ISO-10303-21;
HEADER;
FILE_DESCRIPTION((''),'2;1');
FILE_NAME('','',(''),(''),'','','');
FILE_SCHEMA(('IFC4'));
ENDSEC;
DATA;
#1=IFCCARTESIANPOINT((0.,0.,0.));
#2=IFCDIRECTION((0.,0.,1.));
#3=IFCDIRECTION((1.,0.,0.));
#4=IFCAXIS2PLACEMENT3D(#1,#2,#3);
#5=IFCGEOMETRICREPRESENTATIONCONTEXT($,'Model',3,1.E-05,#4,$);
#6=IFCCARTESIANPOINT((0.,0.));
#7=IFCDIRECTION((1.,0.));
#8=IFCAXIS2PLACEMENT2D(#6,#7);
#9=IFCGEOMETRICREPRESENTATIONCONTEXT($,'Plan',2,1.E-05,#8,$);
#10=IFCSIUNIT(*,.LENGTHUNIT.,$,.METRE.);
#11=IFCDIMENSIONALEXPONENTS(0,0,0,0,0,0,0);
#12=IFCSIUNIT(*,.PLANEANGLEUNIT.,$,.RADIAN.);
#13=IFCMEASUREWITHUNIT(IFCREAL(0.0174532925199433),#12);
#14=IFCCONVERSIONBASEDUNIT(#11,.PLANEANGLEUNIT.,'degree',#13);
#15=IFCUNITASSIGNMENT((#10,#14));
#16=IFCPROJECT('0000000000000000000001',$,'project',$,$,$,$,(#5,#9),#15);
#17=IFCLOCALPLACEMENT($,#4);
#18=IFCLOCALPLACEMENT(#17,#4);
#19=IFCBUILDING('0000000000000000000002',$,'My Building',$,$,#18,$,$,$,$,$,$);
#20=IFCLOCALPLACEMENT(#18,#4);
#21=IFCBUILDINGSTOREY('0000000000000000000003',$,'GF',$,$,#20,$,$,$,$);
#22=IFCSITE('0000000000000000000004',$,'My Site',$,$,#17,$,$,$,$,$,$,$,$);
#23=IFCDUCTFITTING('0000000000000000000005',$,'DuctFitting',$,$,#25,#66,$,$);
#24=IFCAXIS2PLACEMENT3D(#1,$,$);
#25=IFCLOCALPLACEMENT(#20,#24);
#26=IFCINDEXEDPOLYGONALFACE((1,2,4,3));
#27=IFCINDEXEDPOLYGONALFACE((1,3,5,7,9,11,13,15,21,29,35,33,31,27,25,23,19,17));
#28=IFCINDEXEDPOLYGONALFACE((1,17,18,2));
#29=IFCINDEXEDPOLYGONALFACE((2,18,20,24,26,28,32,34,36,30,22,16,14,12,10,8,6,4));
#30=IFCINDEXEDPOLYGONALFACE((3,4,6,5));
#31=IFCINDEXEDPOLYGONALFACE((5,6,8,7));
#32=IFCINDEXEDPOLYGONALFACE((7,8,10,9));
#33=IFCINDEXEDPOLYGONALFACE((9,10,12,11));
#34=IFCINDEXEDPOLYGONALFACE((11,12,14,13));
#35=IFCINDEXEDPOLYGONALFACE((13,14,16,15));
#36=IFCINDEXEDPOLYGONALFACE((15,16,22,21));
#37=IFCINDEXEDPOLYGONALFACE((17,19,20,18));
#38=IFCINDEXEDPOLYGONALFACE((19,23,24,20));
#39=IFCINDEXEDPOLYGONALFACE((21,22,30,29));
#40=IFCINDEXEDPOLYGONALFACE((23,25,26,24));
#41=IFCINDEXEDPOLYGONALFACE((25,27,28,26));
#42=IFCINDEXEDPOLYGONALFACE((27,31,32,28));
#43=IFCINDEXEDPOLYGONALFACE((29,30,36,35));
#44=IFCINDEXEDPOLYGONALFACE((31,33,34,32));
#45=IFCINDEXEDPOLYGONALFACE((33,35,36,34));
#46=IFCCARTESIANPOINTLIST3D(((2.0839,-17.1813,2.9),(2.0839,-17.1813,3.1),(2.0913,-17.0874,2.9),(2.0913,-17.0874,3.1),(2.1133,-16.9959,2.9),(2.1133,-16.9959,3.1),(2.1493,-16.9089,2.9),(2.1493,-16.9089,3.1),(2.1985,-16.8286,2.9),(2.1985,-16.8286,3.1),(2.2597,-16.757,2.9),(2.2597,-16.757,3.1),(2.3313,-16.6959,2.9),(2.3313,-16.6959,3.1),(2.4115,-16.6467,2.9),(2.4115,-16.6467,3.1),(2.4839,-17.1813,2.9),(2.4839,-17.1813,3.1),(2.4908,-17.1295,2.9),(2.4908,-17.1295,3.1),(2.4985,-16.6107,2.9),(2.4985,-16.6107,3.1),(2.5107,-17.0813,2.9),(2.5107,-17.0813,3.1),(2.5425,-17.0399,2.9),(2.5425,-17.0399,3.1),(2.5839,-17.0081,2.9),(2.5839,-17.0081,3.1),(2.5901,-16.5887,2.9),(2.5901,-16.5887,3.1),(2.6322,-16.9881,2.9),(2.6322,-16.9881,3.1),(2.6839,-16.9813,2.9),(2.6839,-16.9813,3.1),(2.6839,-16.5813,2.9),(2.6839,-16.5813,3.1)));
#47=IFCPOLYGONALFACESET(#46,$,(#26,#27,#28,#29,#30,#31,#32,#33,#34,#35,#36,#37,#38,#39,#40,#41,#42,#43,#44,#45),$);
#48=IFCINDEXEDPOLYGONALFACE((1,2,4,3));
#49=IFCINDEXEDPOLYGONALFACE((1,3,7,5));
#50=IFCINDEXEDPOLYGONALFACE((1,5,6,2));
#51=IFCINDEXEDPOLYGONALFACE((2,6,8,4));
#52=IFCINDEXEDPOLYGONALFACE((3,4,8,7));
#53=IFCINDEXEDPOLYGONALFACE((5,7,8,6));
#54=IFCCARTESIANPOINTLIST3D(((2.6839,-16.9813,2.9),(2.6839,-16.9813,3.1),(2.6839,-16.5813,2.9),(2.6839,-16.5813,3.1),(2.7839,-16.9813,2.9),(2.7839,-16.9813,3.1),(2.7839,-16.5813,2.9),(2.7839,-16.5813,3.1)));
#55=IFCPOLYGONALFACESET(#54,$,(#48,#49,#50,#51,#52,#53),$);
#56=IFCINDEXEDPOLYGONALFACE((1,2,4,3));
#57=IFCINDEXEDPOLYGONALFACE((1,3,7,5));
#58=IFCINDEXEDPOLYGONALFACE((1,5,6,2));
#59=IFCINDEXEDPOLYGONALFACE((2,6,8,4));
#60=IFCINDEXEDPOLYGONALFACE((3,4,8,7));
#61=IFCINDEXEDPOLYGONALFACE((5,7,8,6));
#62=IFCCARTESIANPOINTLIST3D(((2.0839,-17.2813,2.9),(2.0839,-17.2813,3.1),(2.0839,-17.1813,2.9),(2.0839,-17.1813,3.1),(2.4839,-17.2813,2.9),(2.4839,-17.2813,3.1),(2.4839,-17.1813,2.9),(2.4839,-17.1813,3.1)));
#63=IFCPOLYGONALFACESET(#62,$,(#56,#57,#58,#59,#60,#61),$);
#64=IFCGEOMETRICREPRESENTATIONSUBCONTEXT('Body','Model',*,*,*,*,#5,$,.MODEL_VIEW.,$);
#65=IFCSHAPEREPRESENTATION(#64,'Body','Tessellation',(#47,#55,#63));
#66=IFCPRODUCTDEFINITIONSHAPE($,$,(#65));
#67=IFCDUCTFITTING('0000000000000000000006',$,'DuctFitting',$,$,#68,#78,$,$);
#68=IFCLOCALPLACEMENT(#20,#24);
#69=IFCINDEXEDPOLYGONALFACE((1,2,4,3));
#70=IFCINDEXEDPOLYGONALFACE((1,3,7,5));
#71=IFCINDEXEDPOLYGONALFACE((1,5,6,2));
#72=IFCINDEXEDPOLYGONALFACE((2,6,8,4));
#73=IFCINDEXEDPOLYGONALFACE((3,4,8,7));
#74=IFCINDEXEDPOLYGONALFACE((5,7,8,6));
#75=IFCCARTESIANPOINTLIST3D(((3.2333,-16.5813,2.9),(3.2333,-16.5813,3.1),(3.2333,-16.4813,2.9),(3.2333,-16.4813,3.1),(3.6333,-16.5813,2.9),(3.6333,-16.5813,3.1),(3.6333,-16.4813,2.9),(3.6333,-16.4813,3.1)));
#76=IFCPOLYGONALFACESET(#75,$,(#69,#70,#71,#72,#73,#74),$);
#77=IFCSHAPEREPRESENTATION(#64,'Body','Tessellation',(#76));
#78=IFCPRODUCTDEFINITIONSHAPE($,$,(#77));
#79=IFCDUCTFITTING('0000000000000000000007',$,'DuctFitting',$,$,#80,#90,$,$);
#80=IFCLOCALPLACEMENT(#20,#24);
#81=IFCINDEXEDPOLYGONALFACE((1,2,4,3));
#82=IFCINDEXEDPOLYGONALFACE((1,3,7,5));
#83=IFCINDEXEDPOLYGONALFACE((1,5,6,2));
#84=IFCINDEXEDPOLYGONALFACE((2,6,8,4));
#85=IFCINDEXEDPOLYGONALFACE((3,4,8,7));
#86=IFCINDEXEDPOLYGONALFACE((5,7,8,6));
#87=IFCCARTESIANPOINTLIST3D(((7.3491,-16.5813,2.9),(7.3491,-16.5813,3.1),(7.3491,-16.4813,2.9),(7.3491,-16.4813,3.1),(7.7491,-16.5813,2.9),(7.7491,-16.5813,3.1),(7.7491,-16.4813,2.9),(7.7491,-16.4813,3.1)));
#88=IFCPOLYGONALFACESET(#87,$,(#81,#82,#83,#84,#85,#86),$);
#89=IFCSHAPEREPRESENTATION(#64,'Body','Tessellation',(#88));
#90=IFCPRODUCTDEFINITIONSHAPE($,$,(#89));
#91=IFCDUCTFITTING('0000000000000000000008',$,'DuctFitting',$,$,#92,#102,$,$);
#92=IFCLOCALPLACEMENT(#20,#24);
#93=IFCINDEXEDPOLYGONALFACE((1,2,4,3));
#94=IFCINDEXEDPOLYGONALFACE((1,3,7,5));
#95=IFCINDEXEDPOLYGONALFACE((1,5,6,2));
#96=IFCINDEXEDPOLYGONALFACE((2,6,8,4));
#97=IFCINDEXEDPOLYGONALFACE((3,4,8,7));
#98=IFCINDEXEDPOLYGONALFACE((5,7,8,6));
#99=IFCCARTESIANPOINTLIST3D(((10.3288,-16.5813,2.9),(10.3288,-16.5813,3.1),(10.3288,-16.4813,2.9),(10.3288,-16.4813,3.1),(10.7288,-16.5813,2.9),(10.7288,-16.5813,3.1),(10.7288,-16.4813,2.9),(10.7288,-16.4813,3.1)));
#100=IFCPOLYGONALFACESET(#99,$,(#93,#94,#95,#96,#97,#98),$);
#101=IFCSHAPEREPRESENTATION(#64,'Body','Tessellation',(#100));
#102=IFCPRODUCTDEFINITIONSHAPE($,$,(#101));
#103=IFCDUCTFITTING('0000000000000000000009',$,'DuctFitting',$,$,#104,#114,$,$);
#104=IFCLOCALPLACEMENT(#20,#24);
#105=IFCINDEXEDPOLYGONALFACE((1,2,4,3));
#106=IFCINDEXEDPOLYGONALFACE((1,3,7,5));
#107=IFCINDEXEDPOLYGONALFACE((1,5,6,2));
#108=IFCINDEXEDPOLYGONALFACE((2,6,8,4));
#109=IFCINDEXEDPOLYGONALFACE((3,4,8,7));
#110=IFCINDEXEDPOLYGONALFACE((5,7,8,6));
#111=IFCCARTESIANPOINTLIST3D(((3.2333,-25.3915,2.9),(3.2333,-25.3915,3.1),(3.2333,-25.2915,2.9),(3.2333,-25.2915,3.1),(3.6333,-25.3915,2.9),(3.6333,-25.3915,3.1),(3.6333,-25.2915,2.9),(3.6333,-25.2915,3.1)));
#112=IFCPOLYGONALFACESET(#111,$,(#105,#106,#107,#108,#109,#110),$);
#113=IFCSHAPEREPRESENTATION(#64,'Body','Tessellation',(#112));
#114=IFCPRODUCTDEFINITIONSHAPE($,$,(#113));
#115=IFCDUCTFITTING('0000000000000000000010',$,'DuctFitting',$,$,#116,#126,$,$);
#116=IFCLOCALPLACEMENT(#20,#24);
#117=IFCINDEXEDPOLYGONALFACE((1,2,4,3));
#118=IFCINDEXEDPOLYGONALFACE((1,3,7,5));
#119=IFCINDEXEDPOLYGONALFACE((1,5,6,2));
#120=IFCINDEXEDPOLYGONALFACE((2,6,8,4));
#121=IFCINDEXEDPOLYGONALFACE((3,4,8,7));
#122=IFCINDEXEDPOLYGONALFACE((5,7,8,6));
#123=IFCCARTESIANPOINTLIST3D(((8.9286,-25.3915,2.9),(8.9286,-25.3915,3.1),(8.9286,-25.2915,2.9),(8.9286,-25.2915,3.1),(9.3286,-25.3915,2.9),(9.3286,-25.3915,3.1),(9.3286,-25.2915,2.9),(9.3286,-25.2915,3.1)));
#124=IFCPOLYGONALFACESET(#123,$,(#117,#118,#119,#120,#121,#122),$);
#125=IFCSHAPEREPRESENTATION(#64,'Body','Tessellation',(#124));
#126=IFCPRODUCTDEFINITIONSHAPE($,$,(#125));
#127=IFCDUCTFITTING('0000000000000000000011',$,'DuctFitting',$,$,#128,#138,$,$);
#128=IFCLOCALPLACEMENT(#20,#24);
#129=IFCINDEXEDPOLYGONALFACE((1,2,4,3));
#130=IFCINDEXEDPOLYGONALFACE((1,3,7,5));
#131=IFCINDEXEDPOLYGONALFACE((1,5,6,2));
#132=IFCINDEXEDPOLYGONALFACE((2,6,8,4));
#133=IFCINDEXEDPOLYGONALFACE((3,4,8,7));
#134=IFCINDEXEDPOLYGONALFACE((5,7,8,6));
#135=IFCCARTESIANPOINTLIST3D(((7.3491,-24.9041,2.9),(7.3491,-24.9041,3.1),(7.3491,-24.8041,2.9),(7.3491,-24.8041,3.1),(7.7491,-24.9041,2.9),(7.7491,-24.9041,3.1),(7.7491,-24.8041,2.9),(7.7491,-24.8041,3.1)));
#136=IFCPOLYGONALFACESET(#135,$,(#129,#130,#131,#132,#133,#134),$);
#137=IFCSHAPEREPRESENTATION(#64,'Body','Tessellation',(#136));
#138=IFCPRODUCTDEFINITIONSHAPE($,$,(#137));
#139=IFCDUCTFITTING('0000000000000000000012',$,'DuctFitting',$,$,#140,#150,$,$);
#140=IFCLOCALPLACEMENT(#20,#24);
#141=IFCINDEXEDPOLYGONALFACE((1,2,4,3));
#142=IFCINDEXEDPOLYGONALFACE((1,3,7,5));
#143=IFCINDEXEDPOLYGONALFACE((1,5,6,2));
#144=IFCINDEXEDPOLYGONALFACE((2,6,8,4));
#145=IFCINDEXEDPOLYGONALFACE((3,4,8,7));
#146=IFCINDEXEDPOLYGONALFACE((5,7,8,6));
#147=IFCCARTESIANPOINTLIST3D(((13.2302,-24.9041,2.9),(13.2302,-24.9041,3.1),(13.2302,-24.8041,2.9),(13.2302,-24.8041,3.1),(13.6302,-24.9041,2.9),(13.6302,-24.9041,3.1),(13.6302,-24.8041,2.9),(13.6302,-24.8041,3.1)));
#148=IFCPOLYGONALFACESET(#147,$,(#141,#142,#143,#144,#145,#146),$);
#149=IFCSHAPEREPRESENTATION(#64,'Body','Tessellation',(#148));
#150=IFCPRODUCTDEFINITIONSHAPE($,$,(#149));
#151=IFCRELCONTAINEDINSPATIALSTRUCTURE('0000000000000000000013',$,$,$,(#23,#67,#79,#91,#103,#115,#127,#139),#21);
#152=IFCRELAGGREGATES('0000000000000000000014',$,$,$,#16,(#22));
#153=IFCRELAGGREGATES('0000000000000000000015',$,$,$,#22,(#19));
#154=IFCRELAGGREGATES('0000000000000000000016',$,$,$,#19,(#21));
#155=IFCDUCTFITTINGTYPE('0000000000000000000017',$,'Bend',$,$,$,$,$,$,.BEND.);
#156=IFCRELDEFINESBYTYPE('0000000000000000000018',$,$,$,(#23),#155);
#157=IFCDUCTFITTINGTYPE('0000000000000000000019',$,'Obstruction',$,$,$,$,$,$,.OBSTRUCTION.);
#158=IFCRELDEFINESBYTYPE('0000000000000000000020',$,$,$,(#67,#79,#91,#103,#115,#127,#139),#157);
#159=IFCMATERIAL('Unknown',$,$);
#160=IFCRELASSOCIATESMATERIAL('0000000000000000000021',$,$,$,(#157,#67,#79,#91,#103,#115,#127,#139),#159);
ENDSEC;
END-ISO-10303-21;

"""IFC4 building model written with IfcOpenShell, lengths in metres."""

from ifc_helpers import new_model, entity, si_unit, converted_unit, frame, origin_with_axes, origin_2d_with_axis, place, context, subcontext, project, spatial, line, arc, indexed_curve, rectangle, outline, extrude, source, transform, mapped, material, material_profile, profile_set, profile_usage, type_object, type_shapes, element, save


model = new_model("IFC4")

# Units and contexts
model_context = context("Model", 3, precision=1e-05, world=origin_with_axes())
plan_context = context("Plan", 2, precision=1e-05, world=origin_2d_with_axis())
body_context_1 = subcontext(model_context, "Body", "Model", "MODEL_VIEW")
ifc_project = project(units=[si_unit("LENGTHUNIT", "METRE"), converted_unit("PLANEANGLEUNIT", "degree", entity("IfcReal", 0.0174532925199433), si_unit("PLANEANGLEUNIT", "RADIAN"), dimensions=[0, 0, 0, 0, 0, 0, 0])], contexts=[model_context, plan_context])

# Site, building, storey
site_placement = place(None, origin_with_axes())
site = spatial("IfcSite", under=ifc_project, at=site_placement, Name="My Site")
building_placement = place(site_placement, origin_with_axes())
building = spatial("IfcBuilding", under=site, at=building_placement, Name="My Building")
storey_placement = place(building_placement, origin_with_axes())
storey = spatial("IfcBuildingStorey", under=building, at=storey_placement, Name="GF")

# Shared definitions
ifc_material = material(Name="Unknown")

# Duct fittings
duct_fitting_type_1 = type_object("IfcDuctFittingType", Name="Bend", PredefinedType="BEND")
shared_shape_1 = source(origin_with_axes(), body_context_1, "Body", "SweptSolid", [
    extrude(outline(indexed_curve([(0.2, 0.0), (0.2586, -0.1414), (0.4, -0.2), (0.4, -0.6), (-0.0243, -0.4243), (-0.2, 0.0)], segments=[arc(1, 2, 3), line(3, 4), arc(4, 5, 6), line(6, 1)])), frame((0.0, -0.1, -0.1), z_axis=(0.0, -1.0, 0.0), x_axis=(1.0, 0.0, 0.0)), (0.0, 0.0, -1.0), 0.2),
    extrude(rectangle(XDim=0.4, YDim=0.2), origin_with_axes(), (0.0, 0.0, -1.0), 0.1),
    extrude(rectangle(XDim=0.4, YDim=0.2), frame((0.4, 0.0, -0.5), z_axis=(1.0, 0.0, 0.0), x_axis=(0.0, 0.0, 1.0)), (0.0, 0.0, 1.0), 0.1),
])
type_shapes(duct_fitting_type_1, [shared_shape_1])
duct_fitting_1_placement = place(storey_placement, frame((2.7839, -16.7813, 3.0), z_axis=(1.0, 0.0, 0.0), x_axis=(0.0, -1.0, 0.0)))
element("IfcDuctFitting", 1, at=duct_fitting_1_placement, inside=storey, type_object=duct_fitting_type_1, Name="DuctFitting", context=body_context_1, shape_type="MappedRepresentation", body=[
    mapped(shared_shape_1, transform((0.0, 0.0, 0.0), x_axis=(1.0, 0.0, 0.0), y_axis=(0.0, 1.0, 0.0), z_axis=(0.0, 0.0, 1.0), scale=1.0)),
])
ifc_material_profile = material_profile(ifc_material, rectangle(XDim=0.4, YDim=0.2))
ifc_profile_set = profile_set([ifc_material_profile])
ifc_profile_usage_1 = profile_usage(ifc_profile_set, cardinal=5)
duct_fitting_type_2 = type_object("IfcDuctFittingType", Name="Obstruction", PredefinedType="OBSTRUCTION", material=ifc_profile_set)
duct_fitting_2_placement = place(storey_placement, frame((3.4333, -16.4813, 3.0), z_axis=(0.0, -1.0, 0.0), x_axis=(1.0, 0.0, 0.0)))
element("IfcDuctFitting", 2, at=duct_fitting_2_placement, inside=storey, type_object=duct_fitting_type_2, material=ifc_profile_usage_1, Name="DuctFitting", context=body_context_1, shape_type="SweptSolid", body=[
    extrude(rectangle(XDim=0.4, YDim=0.2), origin_with_axes(), (0.0, 0.0, 1.0), 0.1),
])
ifc_profile_usage_2 = profile_usage(ifc_profile_set, cardinal=5)
duct_fitting_3_placement = place(storey_placement, frame((7.5491, -16.4813, 3.0), z_axis=(0.0, -1.0, 0.0), x_axis=(1.0, 0.0, 0.0)))
element("IfcDuctFitting", 3, at=duct_fitting_3_placement, inside=storey, type_object=duct_fitting_type_2, material=ifc_profile_usage_2, Name="DuctFitting", context=body_context_1, shape_type="SweptSolid", body=[
    extrude(rectangle(XDim=0.4, YDim=0.2), origin_with_axes(), (0.0, 0.0, 1.0), 0.1),
])
ifc_profile_usage_3 = profile_usage(ifc_profile_set, cardinal=5)
duct_fitting_4_placement = place(storey_placement, frame((10.5288, -16.4813, 3.0), z_axis=(0.0, -1.0, 0.0), x_axis=(1.0, 0.0, 0.0)))
element("IfcDuctFitting", 4, at=duct_fitting_4_placement, inside=storey, type_object=duct_fitting_type_2, material=ifc_profile_usage_3, Name="DuctFitting", context=body_context_1, shape_type="SweptSolid", body=[
    extrude(rectangle(XDim=0.4, YDim=0.2), origin_with_axes(), (0.0, 0.0, 1.0), 0.1),
])
ifc_profile_usage_4 = profile_usage(ifc_profile_set, cardinal=5)
duct_fitting_5_placement = place(storey_placement, frame((3.4333, -25.2915, 3.0), z_axis=(0.0, -1.0, 0.0), x_axis=(1.0, 0.0, 0.0)))
element("IfcDuctFitting", 5, at=duct_fitting_5_placement, inside=storey, type_object=duct_fitting_type_2, material=ifc_profile_usage_4, Name="DuctFitting", context=body_context_1, shape_type="SweptSolid", body=[
    extrude(rectangle(XDim=0.4, YDim=0.2), origin_with_axes(), (0.0, 0.0, 1.0), 0.1),
])
ifc_profile_usage_5 = profile_usage(ifc_profile_set, cardinal=5)
duct_fitting_6_placement = place(storey_placement, frame((9.1286, -25.2915, 3.0), z_axis=(0.0, -1.0, 0.0), x_axis=(1.0, 0.0, 0.0)))
element("IfcDuctFitting", 6, at=duct_fitting_6_placement, inside=storey, type_object=duct_fitting_type_2, material=ifc_profile_usage_5, Name="DuctFitting", context=body_context_1, shape_type="SweptSolid", body=[
    extrude(rectangle(XDim=0.4, YDim=0.2), origin_with_axes(), (0.0, 0.0, 1.0), 0.1),
])
ifc_profile_usage_6 = profile_usage(ifc_profile_set, cardinal=5)
duct_fitting_7_placement = place(storey_placement, frame((7.5491, -24.8041, 3.0), z_axis=(0.0, -1.0, 0.0), x_axis=(1.0, 0.0, 0.0)))
element("IfcDuctFitting", 7, at=duct_fitting_7_placement, inside=storey, type_object=duct_fitting_type_2, material=ifc_profile_usage_6, Name="DuctFitting", context=body_context_1, shape_type="SweptSolid", body=[
    extrude(rectangle(XDim=0.4, YDim=0.2), origin_with_axes(), (0.0, 0.0, 1.0), 0.1),
])
ifc_profile_usage_7 = profile_usage(ifc_profile_set, cardinal=5)
duct_fitting_8_placement = place(storey_placement, frame((13.4302, -24.8041, 3.0), z_axis=(0.0, -1.0, 0.0), x_axis=(1.0, 0.0, 0.0)))
element("IfcDuctFitting", 8, at=duct_fitting_8_placement, inside=storey, type_object=duct_fitting_type_2, material=ifc_profile_usage_7, Name="DuctFitting", context=body_context_1, shape_type="SweptSolid", body=[
    extrude(rectangle(XDim=0.4, YDim=0.2), origin_with_axes(), (0.0, 0.0, 1.0), 0.1),
])

save(model, "model.ifc")
